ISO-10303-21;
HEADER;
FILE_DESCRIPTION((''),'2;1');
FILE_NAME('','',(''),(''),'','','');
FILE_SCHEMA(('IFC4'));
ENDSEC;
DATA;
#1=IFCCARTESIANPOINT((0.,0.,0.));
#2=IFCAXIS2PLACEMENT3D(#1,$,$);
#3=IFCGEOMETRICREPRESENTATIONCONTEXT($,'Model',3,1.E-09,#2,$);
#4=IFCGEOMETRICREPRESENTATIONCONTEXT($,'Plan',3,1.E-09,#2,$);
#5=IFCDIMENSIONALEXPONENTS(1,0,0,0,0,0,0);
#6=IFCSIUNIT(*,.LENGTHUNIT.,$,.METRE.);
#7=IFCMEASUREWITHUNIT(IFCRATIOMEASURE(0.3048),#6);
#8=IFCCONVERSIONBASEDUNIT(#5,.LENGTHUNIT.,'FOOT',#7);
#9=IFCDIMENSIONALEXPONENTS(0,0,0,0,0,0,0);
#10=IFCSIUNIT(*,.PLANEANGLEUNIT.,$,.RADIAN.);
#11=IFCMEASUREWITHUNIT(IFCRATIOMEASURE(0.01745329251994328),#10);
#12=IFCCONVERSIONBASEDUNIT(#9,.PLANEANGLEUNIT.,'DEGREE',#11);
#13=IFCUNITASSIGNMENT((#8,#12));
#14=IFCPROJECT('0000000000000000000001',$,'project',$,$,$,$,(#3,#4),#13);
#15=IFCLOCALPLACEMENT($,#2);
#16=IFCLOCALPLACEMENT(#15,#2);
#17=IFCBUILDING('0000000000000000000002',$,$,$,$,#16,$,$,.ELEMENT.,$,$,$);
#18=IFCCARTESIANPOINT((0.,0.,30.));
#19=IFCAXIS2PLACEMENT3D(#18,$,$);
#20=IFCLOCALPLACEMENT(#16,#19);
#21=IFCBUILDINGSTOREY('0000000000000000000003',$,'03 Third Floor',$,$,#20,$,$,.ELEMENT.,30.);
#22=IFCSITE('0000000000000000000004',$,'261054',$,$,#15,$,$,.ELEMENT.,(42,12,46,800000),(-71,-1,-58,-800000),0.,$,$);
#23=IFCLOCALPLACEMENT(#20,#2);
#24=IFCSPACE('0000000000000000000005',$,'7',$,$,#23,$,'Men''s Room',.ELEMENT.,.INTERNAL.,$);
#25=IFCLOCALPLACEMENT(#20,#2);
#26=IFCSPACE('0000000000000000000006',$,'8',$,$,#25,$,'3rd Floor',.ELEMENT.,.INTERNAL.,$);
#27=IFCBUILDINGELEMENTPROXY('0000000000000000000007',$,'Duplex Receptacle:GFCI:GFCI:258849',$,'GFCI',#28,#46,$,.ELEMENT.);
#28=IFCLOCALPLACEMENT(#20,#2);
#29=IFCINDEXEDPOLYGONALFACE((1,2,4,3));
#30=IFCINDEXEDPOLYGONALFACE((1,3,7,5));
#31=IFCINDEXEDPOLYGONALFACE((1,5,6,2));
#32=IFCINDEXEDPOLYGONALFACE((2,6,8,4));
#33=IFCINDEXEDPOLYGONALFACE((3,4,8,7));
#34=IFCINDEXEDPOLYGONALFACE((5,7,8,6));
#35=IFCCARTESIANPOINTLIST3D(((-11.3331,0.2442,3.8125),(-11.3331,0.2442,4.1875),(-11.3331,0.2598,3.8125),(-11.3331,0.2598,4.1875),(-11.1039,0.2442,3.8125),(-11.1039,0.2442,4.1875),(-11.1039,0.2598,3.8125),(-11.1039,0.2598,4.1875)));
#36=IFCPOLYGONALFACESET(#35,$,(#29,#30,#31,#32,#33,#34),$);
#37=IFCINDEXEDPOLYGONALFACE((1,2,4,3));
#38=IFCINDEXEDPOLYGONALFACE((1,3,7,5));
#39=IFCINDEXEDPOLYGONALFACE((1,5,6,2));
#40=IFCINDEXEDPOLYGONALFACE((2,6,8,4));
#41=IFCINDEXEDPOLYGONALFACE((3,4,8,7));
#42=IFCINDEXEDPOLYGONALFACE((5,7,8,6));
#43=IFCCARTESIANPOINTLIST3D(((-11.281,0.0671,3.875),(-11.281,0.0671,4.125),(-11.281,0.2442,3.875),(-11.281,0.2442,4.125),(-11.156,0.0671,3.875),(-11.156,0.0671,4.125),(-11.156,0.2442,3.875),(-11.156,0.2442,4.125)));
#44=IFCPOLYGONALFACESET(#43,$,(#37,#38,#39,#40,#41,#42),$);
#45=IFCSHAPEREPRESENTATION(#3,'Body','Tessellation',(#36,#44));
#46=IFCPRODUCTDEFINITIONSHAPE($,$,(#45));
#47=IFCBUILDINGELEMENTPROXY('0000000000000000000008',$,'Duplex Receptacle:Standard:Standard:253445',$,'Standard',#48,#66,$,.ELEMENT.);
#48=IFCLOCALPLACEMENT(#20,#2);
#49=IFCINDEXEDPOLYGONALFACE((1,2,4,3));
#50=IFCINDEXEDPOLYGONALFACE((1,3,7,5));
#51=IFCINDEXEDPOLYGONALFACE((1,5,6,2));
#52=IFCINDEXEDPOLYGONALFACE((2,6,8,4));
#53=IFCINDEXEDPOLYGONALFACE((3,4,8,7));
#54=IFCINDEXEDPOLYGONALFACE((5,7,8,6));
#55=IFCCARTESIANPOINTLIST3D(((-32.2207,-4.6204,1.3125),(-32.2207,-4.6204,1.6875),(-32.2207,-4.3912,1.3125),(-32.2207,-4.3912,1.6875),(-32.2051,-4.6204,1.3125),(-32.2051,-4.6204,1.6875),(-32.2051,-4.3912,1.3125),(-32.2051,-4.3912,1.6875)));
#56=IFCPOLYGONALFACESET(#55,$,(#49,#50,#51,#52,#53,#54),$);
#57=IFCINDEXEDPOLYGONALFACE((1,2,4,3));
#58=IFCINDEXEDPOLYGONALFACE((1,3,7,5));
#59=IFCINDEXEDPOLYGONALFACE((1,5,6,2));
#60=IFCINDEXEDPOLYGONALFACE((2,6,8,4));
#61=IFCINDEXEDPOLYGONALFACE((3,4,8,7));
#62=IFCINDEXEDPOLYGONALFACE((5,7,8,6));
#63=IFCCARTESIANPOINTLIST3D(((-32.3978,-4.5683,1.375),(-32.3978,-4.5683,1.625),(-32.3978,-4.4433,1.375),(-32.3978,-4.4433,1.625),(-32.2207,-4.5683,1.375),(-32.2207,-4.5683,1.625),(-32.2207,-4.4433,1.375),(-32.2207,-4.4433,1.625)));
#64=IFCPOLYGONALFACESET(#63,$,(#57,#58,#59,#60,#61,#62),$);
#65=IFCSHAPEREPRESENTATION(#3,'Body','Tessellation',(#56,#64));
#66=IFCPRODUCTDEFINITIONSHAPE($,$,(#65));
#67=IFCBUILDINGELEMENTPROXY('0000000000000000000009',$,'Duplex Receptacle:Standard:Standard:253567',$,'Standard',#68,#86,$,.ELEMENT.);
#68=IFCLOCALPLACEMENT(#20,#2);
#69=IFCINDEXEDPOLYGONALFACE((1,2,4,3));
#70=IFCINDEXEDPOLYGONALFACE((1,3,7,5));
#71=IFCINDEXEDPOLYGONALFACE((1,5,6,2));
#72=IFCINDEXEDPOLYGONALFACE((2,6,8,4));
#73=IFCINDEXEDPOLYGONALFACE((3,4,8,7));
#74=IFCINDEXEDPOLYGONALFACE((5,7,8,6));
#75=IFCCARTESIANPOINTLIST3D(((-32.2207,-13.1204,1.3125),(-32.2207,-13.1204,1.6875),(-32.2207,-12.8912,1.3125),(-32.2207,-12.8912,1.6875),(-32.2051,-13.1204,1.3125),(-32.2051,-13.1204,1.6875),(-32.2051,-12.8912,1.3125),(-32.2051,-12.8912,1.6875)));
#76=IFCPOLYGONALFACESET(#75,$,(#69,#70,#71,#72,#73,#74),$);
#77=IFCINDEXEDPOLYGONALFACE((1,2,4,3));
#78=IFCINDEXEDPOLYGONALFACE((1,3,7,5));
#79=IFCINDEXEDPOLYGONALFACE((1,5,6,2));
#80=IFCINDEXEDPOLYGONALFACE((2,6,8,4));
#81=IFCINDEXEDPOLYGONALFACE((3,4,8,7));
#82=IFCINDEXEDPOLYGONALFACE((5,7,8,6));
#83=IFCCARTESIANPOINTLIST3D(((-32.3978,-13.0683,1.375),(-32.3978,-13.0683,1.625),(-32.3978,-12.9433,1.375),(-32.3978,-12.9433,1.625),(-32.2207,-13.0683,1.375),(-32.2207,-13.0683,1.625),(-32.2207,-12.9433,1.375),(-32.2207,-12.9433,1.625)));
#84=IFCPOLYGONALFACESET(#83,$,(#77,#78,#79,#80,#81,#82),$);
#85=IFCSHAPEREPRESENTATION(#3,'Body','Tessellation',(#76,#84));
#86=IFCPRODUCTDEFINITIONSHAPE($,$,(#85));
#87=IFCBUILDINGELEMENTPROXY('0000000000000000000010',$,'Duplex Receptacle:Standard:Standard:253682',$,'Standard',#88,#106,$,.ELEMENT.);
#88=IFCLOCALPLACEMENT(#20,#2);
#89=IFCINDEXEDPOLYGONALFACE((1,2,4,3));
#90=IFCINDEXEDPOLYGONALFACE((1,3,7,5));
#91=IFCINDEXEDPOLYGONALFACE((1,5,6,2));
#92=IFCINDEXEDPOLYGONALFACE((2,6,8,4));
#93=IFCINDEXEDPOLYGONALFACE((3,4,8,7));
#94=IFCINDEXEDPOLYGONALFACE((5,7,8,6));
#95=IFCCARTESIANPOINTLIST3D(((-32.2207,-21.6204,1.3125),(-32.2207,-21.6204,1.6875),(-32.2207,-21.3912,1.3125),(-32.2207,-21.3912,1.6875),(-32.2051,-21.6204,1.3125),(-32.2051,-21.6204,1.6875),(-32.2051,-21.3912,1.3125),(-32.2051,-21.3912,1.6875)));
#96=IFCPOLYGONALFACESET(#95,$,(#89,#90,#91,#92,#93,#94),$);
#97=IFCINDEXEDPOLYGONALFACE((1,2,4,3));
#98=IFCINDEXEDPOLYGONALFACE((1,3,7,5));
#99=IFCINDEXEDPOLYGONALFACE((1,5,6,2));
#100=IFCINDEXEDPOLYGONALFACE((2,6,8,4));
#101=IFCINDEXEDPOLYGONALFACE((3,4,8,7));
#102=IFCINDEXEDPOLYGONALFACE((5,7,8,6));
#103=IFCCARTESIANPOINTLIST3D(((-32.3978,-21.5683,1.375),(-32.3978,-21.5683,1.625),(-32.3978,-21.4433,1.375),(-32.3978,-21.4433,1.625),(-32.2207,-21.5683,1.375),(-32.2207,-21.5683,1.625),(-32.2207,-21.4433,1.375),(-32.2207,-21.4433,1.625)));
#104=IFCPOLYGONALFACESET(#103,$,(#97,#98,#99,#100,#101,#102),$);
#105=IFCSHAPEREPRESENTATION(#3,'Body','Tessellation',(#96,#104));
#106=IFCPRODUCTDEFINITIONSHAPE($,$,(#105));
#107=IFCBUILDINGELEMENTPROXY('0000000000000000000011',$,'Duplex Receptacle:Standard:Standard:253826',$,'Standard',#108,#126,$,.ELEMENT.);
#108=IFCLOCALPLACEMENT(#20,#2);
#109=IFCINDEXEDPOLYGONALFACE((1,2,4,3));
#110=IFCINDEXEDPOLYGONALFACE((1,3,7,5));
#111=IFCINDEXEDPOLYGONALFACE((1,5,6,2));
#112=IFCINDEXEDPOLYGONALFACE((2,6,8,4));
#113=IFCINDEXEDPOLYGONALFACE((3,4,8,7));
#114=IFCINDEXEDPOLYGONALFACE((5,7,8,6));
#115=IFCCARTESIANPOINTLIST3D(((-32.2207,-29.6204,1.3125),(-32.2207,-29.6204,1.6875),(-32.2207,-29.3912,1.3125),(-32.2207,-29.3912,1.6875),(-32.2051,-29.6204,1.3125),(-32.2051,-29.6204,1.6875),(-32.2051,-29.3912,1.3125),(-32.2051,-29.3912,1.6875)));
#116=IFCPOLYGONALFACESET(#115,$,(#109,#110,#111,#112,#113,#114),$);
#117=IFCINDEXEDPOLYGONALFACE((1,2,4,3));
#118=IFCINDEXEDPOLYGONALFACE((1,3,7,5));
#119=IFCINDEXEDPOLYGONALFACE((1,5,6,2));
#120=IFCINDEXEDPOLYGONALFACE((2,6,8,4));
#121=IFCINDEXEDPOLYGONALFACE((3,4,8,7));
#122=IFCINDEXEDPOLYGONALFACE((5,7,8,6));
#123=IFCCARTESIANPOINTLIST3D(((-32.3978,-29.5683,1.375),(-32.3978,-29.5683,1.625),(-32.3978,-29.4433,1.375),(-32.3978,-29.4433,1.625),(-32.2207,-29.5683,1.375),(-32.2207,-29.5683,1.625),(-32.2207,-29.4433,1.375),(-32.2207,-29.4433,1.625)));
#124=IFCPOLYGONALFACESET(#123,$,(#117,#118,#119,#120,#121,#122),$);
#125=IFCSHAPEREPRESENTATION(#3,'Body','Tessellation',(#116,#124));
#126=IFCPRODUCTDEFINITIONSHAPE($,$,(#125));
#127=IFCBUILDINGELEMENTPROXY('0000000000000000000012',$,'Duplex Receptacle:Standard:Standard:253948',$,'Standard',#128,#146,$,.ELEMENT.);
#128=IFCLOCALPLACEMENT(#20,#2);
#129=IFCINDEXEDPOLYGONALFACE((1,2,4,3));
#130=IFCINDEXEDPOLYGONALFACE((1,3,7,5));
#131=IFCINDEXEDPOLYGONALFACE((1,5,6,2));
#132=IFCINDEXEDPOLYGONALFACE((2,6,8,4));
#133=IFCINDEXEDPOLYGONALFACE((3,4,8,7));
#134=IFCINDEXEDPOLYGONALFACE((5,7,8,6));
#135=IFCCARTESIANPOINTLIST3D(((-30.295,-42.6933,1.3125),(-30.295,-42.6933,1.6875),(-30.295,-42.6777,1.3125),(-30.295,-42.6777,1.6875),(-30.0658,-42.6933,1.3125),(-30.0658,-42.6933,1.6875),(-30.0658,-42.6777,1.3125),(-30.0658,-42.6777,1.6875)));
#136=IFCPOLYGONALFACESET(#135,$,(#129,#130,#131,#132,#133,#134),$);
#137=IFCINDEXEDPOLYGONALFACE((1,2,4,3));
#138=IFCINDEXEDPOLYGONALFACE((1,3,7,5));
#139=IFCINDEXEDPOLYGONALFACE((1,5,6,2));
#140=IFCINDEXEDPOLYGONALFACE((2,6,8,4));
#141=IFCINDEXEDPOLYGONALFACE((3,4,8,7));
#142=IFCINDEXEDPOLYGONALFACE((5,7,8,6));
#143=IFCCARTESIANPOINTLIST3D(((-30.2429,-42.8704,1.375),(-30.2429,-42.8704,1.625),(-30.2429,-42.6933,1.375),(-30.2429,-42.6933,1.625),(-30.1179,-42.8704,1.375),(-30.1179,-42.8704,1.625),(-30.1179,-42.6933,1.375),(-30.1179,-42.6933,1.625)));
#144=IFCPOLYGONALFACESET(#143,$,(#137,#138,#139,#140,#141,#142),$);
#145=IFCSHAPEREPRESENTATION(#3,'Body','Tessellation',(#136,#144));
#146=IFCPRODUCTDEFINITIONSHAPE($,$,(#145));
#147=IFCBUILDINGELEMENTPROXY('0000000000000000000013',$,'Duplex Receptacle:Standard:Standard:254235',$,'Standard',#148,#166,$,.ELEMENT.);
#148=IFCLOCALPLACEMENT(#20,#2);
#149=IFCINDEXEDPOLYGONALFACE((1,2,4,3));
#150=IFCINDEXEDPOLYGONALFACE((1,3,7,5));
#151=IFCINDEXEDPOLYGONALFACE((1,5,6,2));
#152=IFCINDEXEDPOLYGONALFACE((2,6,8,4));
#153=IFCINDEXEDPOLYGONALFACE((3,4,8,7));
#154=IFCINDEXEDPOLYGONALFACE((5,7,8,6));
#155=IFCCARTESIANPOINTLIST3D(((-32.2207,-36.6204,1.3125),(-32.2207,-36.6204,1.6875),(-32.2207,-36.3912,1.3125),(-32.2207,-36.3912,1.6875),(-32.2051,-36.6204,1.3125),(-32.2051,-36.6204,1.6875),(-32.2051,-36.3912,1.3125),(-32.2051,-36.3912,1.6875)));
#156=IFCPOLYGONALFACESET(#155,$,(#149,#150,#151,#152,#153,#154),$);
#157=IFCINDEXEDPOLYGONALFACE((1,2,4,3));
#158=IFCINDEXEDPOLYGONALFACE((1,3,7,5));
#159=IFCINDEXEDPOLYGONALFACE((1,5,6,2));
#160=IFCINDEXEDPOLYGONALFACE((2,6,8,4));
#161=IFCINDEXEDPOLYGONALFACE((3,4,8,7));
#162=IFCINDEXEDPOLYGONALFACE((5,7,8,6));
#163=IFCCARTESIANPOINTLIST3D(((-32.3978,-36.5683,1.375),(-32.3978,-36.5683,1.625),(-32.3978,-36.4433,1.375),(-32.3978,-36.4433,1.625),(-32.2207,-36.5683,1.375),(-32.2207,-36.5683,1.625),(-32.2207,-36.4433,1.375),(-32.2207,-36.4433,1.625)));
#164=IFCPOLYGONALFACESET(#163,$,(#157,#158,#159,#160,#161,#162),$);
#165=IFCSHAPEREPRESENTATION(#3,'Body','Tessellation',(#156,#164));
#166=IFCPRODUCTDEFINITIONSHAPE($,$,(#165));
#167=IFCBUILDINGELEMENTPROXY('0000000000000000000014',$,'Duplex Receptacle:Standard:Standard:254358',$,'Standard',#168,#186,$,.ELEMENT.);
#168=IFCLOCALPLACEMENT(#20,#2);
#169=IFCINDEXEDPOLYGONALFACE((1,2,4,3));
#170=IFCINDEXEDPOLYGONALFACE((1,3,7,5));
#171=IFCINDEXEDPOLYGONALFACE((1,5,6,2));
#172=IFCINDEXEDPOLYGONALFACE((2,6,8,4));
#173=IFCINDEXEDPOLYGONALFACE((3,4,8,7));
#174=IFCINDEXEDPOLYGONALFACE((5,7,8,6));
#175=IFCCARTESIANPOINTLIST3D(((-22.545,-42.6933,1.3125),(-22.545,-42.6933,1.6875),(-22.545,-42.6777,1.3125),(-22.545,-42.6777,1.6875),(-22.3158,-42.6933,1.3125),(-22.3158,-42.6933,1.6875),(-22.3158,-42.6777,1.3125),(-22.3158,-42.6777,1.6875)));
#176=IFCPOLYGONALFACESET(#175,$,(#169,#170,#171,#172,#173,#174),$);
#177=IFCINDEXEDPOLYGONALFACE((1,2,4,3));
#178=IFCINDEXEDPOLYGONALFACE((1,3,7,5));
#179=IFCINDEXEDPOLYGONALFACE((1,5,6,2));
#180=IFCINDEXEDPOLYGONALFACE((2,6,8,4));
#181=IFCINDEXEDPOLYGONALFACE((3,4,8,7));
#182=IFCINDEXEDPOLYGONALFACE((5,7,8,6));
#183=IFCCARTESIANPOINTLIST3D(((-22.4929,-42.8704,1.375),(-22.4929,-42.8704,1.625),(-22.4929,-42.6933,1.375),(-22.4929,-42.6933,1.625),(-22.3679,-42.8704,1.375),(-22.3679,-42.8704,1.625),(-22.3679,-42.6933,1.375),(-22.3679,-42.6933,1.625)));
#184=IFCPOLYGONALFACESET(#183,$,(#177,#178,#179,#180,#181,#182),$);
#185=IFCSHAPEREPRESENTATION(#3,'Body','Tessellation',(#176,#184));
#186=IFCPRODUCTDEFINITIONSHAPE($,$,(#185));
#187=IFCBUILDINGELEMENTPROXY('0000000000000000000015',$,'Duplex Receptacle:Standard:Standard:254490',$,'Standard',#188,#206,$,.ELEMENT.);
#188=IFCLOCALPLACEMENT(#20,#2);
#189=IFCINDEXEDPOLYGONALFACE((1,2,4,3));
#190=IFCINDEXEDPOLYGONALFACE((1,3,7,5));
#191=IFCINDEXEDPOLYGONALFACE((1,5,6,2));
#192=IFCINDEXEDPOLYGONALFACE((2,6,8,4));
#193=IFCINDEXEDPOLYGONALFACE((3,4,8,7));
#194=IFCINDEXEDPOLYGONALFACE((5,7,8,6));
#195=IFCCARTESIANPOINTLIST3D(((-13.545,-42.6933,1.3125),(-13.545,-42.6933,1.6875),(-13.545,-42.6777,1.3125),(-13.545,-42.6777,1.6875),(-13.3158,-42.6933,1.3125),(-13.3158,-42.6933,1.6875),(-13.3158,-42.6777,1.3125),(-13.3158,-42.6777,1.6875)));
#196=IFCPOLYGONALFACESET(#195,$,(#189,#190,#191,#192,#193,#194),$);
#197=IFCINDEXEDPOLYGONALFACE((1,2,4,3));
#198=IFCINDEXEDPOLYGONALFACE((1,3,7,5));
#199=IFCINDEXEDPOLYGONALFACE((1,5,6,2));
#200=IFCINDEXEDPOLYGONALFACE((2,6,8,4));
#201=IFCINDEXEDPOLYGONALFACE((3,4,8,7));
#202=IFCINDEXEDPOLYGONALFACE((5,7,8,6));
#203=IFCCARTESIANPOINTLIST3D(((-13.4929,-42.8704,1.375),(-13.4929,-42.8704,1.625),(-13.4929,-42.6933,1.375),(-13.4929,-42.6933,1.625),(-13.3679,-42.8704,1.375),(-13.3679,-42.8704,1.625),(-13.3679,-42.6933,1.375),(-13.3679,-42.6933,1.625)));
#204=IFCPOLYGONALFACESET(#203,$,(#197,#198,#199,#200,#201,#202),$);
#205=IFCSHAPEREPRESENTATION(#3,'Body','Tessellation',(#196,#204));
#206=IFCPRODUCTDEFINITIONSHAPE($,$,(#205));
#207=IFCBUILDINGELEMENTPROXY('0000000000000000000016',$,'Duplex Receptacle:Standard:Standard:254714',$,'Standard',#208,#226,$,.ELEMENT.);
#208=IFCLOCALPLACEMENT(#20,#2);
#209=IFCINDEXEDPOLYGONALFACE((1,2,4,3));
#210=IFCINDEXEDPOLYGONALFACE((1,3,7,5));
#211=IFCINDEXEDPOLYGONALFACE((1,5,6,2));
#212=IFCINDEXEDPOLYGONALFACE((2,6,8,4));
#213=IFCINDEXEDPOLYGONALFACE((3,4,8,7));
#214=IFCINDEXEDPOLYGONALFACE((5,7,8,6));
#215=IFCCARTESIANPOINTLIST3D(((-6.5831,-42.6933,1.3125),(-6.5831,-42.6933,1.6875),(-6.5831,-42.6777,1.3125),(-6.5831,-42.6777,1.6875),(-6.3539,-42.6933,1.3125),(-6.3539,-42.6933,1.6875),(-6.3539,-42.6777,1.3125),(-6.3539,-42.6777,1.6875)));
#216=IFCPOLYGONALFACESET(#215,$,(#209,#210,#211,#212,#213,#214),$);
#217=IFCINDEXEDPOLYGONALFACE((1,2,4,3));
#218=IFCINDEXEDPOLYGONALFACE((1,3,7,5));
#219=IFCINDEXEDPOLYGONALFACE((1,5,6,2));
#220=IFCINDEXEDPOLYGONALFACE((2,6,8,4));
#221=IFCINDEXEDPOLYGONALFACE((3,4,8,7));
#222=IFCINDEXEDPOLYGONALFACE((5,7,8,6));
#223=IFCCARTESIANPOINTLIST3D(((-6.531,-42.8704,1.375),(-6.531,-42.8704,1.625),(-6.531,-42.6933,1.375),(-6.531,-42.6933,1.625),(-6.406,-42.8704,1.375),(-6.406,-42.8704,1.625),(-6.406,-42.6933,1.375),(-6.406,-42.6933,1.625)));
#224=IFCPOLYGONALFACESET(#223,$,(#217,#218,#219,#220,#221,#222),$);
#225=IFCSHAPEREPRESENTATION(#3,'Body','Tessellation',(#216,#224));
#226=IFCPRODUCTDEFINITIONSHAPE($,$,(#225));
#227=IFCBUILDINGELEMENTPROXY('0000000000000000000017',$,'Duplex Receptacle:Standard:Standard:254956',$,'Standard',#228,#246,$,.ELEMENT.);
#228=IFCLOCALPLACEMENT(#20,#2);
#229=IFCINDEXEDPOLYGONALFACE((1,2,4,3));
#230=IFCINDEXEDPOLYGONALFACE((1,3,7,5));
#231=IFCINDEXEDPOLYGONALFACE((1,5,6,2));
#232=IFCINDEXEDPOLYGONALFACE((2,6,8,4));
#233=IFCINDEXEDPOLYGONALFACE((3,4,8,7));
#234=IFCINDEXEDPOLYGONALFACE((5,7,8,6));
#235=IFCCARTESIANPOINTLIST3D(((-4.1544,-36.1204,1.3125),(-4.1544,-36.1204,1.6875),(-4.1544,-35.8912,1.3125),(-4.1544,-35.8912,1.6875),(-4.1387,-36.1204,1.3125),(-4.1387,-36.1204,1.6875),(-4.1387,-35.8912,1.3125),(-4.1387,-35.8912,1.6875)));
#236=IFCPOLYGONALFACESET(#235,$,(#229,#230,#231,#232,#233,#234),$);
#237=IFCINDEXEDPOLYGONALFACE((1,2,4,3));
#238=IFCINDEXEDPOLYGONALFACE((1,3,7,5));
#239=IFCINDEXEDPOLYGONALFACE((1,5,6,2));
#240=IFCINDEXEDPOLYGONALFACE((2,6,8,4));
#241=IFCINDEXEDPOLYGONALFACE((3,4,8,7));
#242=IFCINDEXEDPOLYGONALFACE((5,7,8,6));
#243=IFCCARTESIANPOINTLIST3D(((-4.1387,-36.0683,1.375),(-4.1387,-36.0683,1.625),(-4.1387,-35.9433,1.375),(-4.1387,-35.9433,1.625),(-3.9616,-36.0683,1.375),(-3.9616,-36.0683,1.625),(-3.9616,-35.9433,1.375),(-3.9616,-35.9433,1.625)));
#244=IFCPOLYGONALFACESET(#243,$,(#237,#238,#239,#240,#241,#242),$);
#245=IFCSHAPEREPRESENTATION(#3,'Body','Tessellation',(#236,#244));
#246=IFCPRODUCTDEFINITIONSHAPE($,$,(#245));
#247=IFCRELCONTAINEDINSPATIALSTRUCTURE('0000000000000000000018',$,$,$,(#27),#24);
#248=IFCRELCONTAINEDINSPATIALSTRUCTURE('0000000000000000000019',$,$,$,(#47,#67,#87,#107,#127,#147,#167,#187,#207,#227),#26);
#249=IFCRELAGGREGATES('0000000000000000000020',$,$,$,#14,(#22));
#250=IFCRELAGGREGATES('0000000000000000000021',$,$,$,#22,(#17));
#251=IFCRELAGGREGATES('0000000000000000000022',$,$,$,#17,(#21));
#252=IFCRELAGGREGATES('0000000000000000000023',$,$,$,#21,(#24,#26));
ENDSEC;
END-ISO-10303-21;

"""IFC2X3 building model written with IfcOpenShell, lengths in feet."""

from ifc_helpers import new_model, entity, si_unit, converted_unit, frame, origin, origin_2d_with_axis, place, context, project, spatial, rectangle, extrude, source, transform, mapped, element, save


model = new_model("IFC2X3")

# Units and contexts
model_context = context("Model", 3, precision=1e-09, world=origin())
plan_context = context("Plan", 3, precision=1e-09, world=origin())
ifc_project = project(units=[converted_unit("LENGTHUNIT", "FOOT", entity("IfcRatioMeasure", 0.3048), si_unit("LENGTHUNIT", "METRE"), dimensions=[1, 0, 0, 0, 0, 0, 0]), converted_unit("PLANEANGLEUNIT", "DEGREE", entity("IfcRatioMeasure", 0.01745329251994328), si_unit("PLANEANGLEUNIT", "RADIAN"), dimensions=[0, 0, 0, 0, 0, 0, 0])], contexts=[model_context, plan_context])

# Site, building, storey
site_placement = place(None, origin())
site = spatial("IfcSite", under=ifc_project, at=site_placement, Name="261054", CompositionType="ELEMENT", RefLatitude=(42, 12, 46, 800000), RefLongitude=(-71, -1, -58, -800000), RefElevation=0.0)
building_placement = place(site_placement, origin())
building = spatial("IfcBuilding", under=site, at=building_placement, CompositionType="ELEMENT")
storey_placement = place(building_placement, frame((0.0, 0.0, 30.0)))
storey = spatial("IfcBuildingStorey", under=building, at=storey_placement, Name="03 Third Floor", CompositionType="ELEMENT", Elevation=30.0)

# Shared definitions
space_1_placement = place(storey_placement, origin())
space_1 = spatial("IfcSpace", under=storey, at=space_1_placement, Name="7", LongName="Men's Room", CompositionType="ELEMENT", InteriorOrExteriorSpace="INTERNAL")

# Building element proxy
shared_shape_1 = source(origin(), model_context, "Body", "SweptSolid", [
    extrude(rectangle(XDim=0.2292, YDim=0.375, at=origin_2d_with_axis()), frame((0.0, 0.0, 0.0), z_axis=(0.0, 0.0, 1.0), x_axis=(-1.0, 0.0, 0.0)), (0.0, 0.0, 1.0), 0.0156),
    extrude(rectangle(XDim=0.125, YDim=0.25, at=origin_2d_with_axis()), frame((0.0, 0.0, -0.1771), z_axis=(0.0, 0.0, 1.0), x_axis=(-1.0, 0.0, 0.0)), (0.0, 0.0, 1.0), 0.1771),
])
proxy_placement = place(space_1_placement, frame((-11.2185, 0.2442, 4.0), z_axis=(0.0, 1.0, 0.0), x_axis=(-1.0, 0.0, 0.0)))
element("IfcBuildingElementProxy", 1, at=proxy_placement, inside=space_1, Name="Duplex Receptacle:GFCI:GFCI:258849", ObjectType="GFCI", CompositionType="ELEMENT", context=model_context, shape_type="MappedRepresentation", body=[
    mapped(shared_shape_1, transform((0.0, 0.0, 0.0), scale=1.0)),
])

# Shared definitions
space_2_placement = place(storey_placement, origin())
space_2 = spatial("IfcSpace", under=storey, at=space_2_placement, Name="8", LongName="3rd Floor", CompositionType="ELEMENT", InteriorOrExteriorSpace="INTERNAL")

# Building element proxies
shared_shape_2 = source(origin(), model_context, "Body", "SweptSolid", [
    extrude(rectangle(XDim=0.2292, YDim=0.375, at=origin_2d_with_axis()), frame((0.0, 0.0, 0.0), z_axis=(0.0, 0.0, 1.0), x_axis=(-1.0, 0.0, 0.0)), (0.0, 0.0, 1.0), 0.0156),
    extrude(rectangle(XDim=0.125, YDim=0.25, at=origin_2d_with_axis()), frame((0.0, 0.0, -0.1771), z_axis=(0.0, 0.0, 1.0), x_axis=(-1.0, 0.0, 0.0)), (0.0, 0.0, 1.0), 0.1771),
])
for number, where, z_axis, x_axis, name in (
    (2, (-32.2207, -4.5058, 1.5), (1.0, 0.0, 0.0), (0.0, 1.0, 0.0), "Duplex Receptacle:Standard:Standard:253445"),
    (3, (-32.2207, -13.0058, 1.5), (1.0, 0.0, 0.0), (0.0, 1.0, 0.0), "Duplex Receptacle:Standard:Standard:253567"),
    (4, (-32.2207, -21.5058, 1.5), (1.0, 0.0, 0.0), (0.0, 1.0, 0.0), "Duplex Receptacle:Standard:Standard:253682"),
    (5, (-32.2207, -29.5058, 1.5), (1.0, 0.0, 0.0), (0.0, 1.0, 0.0), "Duplex Receptacle:Standard:Standard:253826"),
    (6, (-30.1804, -42.6933, 1.5), (0.0, 1.0, 0.0), (-1.0, 0.0, 0.0), "Duplex Receptacle:Standard:Standard:253948"),
    (7, (-32.2207, -36.5058, 1.5), (1.0, 0.0, 0.0), (0.0, 1.0, 0.0), "Duplex Receptacle:Standard:Standard:254235"),
    (8, (-22.4304, -42.6933, 1.5), (0.0, 1.0, 0.0), (-1.0, 0.0, 0.0), "Duplex Receptacle:Standard:Standard:254358"),
    (9, (-13.4304, -42.6933, 1.5), (0.0, 1.0, 0.0), (-1.0, 0.0, 0.0), "Duplex Receptacle:Standard:Standard:254490"),
    (10, (-6.4685, -42.6933, 1.5), (0.0, 1.0, 0.0), (-1.0, 0.0, 0.0), "Duplex Receptacle:Standard:Standard:254714"),
    (11, (-4.1387, -36.0058, 1.5), (-1.0, 0.0, 0.0), (0.0, -1.0, 0.0), "Duplex Receptacle:Standard:Standard:254956"),
):
    element("IfcBuildingElementProxy", number, at=place(space_2_placement, frame(where, z_axis=z_axis, x_axis=x_axis)), inside=space_2, Name=name, ObjectType="Standard", CompositionType="ELEMENT", context=model_context, shape_type="MappedRepresentation", body=[
        mapped(shared_shape_2, transform((0.0, 0.0, 0.0), scale=1.0)),
    ])

save(model, "model.ifc")
